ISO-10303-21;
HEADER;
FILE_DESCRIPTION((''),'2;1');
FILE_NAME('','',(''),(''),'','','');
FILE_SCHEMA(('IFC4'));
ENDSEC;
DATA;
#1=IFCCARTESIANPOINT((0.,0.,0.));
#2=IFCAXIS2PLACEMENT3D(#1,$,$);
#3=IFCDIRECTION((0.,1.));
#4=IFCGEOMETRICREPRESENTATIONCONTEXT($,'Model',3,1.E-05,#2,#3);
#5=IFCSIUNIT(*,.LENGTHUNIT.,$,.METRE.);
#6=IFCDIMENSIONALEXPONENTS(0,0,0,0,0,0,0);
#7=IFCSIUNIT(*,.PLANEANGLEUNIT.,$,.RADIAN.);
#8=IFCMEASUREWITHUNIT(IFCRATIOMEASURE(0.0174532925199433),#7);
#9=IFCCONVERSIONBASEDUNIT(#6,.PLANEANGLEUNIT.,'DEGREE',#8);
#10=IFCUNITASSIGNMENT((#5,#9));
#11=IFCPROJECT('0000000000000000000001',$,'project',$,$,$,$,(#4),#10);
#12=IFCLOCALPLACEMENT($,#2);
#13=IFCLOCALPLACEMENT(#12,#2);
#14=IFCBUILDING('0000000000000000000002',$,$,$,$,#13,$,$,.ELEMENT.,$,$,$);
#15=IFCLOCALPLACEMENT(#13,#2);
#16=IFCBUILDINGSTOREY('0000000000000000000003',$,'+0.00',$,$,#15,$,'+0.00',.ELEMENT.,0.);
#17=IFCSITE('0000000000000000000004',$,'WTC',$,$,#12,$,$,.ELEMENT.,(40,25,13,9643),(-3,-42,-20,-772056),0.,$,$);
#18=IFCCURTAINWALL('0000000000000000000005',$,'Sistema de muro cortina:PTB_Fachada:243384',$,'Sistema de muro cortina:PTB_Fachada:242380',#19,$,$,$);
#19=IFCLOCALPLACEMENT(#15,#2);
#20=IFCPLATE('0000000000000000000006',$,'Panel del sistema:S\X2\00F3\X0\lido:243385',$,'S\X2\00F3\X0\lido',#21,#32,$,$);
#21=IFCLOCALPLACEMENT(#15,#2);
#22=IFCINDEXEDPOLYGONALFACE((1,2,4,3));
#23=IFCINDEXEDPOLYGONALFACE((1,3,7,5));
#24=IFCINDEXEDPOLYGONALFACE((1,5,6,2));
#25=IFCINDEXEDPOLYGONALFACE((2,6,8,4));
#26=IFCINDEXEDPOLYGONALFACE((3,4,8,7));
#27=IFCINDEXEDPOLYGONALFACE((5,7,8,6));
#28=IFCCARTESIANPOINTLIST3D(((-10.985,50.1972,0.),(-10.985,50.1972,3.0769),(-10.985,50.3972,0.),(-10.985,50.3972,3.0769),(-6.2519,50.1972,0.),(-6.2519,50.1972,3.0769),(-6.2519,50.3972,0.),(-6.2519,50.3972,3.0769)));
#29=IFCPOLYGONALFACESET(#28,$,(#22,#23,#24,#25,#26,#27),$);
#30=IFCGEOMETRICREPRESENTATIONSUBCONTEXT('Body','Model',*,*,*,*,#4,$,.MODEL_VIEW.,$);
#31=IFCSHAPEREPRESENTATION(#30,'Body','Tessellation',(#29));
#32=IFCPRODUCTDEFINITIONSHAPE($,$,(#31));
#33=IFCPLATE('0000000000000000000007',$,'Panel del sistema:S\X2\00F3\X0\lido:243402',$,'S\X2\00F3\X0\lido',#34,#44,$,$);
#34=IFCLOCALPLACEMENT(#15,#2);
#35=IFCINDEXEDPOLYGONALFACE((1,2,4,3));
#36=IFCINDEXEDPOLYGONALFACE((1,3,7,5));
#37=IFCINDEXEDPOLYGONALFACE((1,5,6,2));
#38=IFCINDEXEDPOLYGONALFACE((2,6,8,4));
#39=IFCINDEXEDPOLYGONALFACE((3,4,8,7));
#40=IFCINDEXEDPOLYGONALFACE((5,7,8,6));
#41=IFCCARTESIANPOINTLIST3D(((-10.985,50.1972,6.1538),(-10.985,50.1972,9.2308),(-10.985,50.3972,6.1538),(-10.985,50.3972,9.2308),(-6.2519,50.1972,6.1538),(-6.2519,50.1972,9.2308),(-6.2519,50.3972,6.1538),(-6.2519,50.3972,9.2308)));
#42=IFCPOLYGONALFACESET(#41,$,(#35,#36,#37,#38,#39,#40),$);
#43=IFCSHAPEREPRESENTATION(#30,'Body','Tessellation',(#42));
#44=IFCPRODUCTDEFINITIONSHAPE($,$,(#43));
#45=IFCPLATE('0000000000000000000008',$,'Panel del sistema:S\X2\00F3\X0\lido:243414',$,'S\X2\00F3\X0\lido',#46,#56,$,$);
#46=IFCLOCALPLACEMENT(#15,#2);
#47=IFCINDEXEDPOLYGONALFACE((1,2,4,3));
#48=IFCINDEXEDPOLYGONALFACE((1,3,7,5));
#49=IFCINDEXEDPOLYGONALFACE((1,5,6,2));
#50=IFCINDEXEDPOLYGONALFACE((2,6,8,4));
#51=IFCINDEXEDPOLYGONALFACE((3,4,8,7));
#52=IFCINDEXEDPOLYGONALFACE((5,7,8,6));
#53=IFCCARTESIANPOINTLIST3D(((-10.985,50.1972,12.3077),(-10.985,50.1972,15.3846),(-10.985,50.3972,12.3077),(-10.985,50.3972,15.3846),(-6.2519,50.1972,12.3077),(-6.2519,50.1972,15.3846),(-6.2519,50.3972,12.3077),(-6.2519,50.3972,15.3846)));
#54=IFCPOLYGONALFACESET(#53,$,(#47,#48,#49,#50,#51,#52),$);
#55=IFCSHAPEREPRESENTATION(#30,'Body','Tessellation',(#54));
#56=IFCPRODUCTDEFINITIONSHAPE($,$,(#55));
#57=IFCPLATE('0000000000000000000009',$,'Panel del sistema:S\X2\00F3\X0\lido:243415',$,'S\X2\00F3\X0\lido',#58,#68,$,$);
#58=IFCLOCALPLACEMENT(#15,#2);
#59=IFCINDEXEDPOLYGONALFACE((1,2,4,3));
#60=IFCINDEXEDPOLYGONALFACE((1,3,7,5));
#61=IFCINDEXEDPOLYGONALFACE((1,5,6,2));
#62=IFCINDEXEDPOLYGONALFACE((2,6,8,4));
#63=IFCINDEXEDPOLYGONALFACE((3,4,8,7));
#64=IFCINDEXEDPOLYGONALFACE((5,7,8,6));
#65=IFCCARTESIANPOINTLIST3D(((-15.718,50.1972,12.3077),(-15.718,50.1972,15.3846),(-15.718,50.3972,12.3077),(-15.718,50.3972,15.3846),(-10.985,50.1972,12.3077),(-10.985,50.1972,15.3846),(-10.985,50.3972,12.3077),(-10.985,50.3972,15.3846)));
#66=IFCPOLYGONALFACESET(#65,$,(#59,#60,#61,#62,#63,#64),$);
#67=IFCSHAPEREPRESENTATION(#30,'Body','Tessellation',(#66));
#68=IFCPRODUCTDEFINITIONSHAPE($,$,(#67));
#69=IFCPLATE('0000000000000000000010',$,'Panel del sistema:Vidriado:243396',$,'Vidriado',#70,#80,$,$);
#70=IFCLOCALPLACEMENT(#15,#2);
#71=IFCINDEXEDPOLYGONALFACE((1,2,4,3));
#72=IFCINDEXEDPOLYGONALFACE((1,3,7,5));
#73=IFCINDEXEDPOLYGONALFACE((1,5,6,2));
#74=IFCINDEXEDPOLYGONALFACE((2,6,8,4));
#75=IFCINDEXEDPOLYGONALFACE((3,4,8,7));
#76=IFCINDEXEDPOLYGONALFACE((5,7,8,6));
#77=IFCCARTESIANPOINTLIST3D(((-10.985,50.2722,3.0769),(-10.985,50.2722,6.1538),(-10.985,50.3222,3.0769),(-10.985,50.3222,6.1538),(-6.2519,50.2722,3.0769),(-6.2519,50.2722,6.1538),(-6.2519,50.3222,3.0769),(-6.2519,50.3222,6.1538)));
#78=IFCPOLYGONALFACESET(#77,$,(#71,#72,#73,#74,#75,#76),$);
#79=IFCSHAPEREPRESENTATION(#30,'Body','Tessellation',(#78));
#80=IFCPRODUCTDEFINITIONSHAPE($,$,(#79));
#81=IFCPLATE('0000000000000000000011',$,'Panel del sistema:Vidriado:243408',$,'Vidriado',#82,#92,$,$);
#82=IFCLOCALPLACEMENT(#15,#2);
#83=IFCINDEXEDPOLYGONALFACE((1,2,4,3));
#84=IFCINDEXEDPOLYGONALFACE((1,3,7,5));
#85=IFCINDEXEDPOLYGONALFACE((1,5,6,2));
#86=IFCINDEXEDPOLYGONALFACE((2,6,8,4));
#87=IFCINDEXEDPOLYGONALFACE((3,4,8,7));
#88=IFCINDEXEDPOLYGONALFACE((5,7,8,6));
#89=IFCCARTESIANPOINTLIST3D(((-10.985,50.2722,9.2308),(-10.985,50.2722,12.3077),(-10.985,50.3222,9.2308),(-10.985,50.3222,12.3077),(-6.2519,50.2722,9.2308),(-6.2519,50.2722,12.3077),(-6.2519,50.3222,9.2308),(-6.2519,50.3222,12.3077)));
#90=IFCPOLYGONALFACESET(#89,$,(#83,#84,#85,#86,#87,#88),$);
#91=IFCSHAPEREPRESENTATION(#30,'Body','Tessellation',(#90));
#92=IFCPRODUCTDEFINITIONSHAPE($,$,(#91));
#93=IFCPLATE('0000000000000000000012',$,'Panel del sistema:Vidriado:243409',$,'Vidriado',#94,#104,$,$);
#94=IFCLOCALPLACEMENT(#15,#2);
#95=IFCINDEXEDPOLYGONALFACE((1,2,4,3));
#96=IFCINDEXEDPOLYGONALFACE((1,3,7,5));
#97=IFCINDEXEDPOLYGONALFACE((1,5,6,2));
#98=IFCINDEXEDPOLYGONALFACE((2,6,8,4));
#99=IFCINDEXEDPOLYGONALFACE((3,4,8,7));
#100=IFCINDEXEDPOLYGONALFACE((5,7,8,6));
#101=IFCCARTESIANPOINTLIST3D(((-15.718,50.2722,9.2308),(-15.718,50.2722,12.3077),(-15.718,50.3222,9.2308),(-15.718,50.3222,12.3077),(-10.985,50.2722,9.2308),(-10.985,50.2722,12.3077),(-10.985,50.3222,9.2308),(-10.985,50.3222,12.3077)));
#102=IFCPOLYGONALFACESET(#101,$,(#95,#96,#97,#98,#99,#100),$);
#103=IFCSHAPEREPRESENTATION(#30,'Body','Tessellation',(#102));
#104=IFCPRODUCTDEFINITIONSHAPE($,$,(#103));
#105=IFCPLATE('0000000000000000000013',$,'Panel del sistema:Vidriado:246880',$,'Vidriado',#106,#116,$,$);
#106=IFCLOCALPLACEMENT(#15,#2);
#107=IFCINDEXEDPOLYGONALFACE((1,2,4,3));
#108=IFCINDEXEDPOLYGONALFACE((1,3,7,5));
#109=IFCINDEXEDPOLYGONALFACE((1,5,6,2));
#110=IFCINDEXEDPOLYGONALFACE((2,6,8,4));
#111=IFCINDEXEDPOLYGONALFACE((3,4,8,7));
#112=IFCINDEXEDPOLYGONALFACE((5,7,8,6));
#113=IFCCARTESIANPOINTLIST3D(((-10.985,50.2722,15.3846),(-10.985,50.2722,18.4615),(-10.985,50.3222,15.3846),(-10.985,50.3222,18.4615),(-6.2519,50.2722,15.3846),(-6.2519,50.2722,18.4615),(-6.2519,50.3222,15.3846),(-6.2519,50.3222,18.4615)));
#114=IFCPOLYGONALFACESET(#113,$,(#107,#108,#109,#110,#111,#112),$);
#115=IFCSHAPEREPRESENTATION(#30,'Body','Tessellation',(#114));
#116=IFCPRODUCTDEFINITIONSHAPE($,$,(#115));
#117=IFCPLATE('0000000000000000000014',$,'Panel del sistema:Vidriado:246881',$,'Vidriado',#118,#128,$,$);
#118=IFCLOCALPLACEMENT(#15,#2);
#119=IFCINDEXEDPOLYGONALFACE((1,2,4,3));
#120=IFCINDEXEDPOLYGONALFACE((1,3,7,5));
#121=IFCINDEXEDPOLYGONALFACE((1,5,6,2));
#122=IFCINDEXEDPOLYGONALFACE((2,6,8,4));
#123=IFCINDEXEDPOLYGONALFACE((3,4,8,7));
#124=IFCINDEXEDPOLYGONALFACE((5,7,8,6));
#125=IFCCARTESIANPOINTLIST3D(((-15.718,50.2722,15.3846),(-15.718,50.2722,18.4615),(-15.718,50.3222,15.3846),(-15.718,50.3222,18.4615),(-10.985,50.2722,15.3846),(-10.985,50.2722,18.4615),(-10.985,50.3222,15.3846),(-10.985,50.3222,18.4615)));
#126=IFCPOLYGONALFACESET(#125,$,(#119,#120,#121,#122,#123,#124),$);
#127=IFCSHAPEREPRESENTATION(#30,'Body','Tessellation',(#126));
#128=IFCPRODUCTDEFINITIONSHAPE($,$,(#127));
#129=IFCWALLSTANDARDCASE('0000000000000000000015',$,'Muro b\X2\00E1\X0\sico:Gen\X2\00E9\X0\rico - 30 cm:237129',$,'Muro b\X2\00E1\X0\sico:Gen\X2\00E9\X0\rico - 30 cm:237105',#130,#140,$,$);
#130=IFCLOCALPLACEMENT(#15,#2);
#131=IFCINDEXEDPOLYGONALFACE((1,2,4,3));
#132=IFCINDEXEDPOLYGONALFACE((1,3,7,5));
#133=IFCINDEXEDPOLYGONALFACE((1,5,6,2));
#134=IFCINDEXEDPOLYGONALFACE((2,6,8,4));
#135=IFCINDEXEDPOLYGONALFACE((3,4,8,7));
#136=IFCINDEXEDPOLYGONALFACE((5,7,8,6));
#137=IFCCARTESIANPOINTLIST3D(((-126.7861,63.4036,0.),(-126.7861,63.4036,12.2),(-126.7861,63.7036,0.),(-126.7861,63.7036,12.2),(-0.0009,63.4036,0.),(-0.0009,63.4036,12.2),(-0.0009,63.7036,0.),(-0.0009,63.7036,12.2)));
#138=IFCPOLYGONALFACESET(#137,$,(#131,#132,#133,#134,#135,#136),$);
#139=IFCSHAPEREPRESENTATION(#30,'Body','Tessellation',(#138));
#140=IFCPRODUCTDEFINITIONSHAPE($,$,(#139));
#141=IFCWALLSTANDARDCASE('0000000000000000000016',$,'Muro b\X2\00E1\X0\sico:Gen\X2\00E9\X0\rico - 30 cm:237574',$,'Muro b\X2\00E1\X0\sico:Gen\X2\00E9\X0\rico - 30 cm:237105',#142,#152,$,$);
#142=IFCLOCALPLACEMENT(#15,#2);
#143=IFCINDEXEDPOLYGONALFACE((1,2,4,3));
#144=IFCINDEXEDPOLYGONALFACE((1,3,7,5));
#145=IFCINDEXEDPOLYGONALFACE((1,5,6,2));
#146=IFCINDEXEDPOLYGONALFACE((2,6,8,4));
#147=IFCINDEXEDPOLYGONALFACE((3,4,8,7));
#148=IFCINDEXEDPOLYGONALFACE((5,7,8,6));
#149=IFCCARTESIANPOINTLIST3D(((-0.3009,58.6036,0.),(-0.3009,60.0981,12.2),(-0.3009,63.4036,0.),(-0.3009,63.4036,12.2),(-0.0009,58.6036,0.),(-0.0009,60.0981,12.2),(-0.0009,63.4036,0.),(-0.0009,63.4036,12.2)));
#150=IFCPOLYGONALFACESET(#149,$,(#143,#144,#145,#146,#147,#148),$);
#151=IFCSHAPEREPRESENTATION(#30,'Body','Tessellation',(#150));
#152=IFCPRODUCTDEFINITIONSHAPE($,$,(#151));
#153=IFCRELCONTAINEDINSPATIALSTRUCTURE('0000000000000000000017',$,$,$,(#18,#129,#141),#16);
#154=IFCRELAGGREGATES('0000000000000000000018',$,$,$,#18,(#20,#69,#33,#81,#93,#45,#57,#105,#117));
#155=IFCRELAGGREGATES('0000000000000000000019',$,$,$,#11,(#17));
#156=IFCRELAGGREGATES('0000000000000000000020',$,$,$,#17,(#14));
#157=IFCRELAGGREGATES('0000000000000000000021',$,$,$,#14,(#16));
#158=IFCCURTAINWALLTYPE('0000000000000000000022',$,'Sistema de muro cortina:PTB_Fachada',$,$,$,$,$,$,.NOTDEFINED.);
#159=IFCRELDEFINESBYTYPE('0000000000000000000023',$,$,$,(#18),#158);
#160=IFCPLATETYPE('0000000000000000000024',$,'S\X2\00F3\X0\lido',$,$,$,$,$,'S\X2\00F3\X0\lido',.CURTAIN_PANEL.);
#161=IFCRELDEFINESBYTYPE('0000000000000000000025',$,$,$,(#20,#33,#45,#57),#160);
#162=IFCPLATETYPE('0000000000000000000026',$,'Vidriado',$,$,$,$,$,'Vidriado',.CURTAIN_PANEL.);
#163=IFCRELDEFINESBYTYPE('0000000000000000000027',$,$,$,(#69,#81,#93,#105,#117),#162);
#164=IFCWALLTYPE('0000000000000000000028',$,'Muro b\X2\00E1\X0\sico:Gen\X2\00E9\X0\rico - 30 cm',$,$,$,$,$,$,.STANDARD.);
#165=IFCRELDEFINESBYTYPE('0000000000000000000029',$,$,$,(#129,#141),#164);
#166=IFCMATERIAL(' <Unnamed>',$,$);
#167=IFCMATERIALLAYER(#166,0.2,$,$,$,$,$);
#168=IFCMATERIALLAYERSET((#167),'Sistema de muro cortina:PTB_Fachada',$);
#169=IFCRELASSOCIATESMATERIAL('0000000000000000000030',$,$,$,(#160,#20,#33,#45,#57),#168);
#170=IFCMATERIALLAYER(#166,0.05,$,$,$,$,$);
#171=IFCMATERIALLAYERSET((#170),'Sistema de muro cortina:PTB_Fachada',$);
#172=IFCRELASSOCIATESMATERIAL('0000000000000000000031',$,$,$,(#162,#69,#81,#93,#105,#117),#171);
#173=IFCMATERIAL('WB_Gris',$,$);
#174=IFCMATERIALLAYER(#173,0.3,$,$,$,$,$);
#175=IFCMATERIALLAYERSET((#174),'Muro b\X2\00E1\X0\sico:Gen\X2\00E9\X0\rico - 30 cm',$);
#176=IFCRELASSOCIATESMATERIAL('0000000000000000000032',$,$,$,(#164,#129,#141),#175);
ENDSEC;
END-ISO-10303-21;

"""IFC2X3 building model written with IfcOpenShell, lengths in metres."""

from ifc_helpers import new_model, entity, si_unit, converted_unit, direction, frame, frame_2d, origin, origin_2d_with_axis, place, context, subcontext, project, spatial, polyline, rectangle, extrude, clip, halfspace, bounded_halfspace, source, transform, mapped, material, layer, layer_set, layer_usage, type_object, type_shapes, element, aggregate, save


model = new_model("IFC2X3")

# Units and contexts
model_context = context("Model", 3, precision=1e-05, world=origin(), true_north=direction((0.0, 1.0)))
body_context = subcontext(model_context, "Body", "Model", "MODEL_VIEW")
ifc_project = project(units=[si_unit("LENGTHUNIT", "METRE"), converted_unit("PLANEANGLEUNIT", "DEGREE", entity("IfcRatioMeasure", 0.0174532925199433), si_unit("PLANEANGLEUNIT", "RADIAN"), dimensions=[0, 0, 0, 0, 0, 0, 0])], contexts=[model_context])

# Site, building, storey
site_placement = place(None, origin())
site = spatial("IfcSite", under=ifc_project, at=site_placement, Name="WTC", CompositionType="ELEMENT", RefLatitude=(40, 25, 13, 9643), RefLongitude=(-3, -42, -20, -772056), RefElevation=0.0)
building_placement = place(site_placement, origin())
building = spatial("IfcBuilding", under=site, at=building_placement, CompositionType="ELEMENT")
storey_placement = place(building_placement, origin())
storey = spatial("IfcBuildingStorey", under=building, at=storey_placement, Name="+0.00", LongName="+0.00", CompositionType="ELEMENT", Elevation=0.0)

# Curtain wall, plates
curtain_wall_type = type_object("IfcCurtainWallType", Name="Sistema de muro cortina:PTB_Fachada", PredefinedType="NOTDEFINED")
ifc_material_1 = material(Name=" <Unnamed>")
ifc_layer_1 = layer(ifc_material_1, 0.2)
ifc_layer_set_1 = layer_set([ifc_layer_1], Name="Sistema de muro cortina:PTB_Fachada")
ifc_layer_2 = layer(ifc_material_1, 0.05)
ifc_layer_set_2 = layer_set([ifc_layer_2], Name="Sistema de muro cortina:PTB_Fachada")
curtain_wall_1_placement = place(storey_placement, origin())
curtain_wall_1 = element("IfcCurtainWall", 1, at=curtain_wall_1_placement, inside=storey, type_object=curtain_wall_type, Name="Sistema de muro cortina:PTB_Fachada:243384", ObjectType="Sistema de muro cortina:PTB_Fachada:242380")
ifc_layer_usage_1 = layer_usage(ifc_layer_set_1, "AXIS3", "POSITIVE", 0.0)
plate_type_1 = type_object("IfcPlateType", Name="Sólido", ElementType="Sólido", PredefinedType="CURTAIN_PANEL", material=ifc_layer_set_1)
shared_shape_1 = source(origin(), body_context, "Body", "SweptSolid", [
    extrude(rectangle(XDim=0.2, YDim=4.7331, at=frame_2d((0.0, 0.0), x_axis=(1.0, 0.0))), frame((0.0, 0.0, 0.0), z_axis=(0.0, 0.0, 1.0), x_axis=(0.0, 1.0, 0.0)), (0.0, 0.0, 1.0), 3.0769),
])
type_shapes(plate_type_1, [shared_shape_1])
plate_1_placement = place(curtain_wall_1_placement, frame((-8.6184, 50.2972, 0.0), z_axis=(0.0, 0.0, 1.0), x_axis=(-1.0, 0.0, 0.0)))
plate_1 = element("IfcPlate", 2, at=plate_1_placement, type_object=plate_type_1, material=ifc_layer_usage_1, Name="Panel del sistema:Sólido:243385", ObjectType="Sólido", context=body_context, shape_type="MappedRepresentation", body=[
    mapped(shared_shape_1, transform((0.0, 0.0, 0.0), scale=1.0)),
])
ifc_layer_usage_2 = layer_usage(ifc_layer_set_1, "AXIS3", "POSITIVE", 0.0)
plate_2_placement = place(curtain_wall_1_placement, frame((-8.6184, 50.2972, 6.1538), z_axis=(0.0, 0.0, 1.0), x_axis=(-1.0, 0.0, 0.0)))
plate_2 = element("IfcPlate", 3, at=plate_2_placement, type_object=plate_type_1, material=ifc_layer_usage_2, Name="Panel del sistema:Sólido:243402", ObjectType="Sólido", context=body_context, shape_type="MappedRepresentation", body=[
    mapped(shared_shape_1, transform((0.0, 0.0, 0.0), scale=1.0)),
])
ifc_layer_usage_3 = layer_usage(ifc_layer_set_1, "AXIS3", "POSITIVE", 0.0)
plate_3_placement = place(curtain_wall_1_placement, frame((-8.6184, 50.2972, 12.3077), z_axis=(0.0, 0.0, 1.0), x_axis=(-1.0, 0.0, 0.0)))
plate_3 = element("IfcPlate", 4, at=plate_3_placement, type_object=plate_type_1, material=ifc_layer_usage_3, Name="Panel del sistema:Sólido:243414", ObjectType="Sólido", context=body_context, shape_type="MappedRepresentation", body=[
    mapped(shared_shape_1, transform((0.0, 0.0, 0.0), scale=1.0)),
])
ifc_layer_usage_4 = layer_usage(ifc_layer_set_1, "AXIS3", "POSITIVE", 0.0)
plate_4_placement = place(curtain_wall_1_placement, frame((-13.3515, 50.2972, 12.3077), z_axis=(0.0, 0.0, 1.0), x_axis=(-1.0, 0.0, 0.0)))
plate_4 = element("IfcPlate", 5, at=plate_4_placement, type_object=plate_type_1, material=ifc_layer_usage_4, Name="Panel del sistema:Sólido:243415", ObjectType="Sólido", context=body_context, shape_type="MappedRepresentation", body=[
    mapped(shared_shape_1, transform((0.0, 0.0, 0.0), scale=1.0)),
])
ifc_layer_usage_5 = layer_usage(ifc_layer_set_2, "AXIS3", "POSITIVE", 0.0)
plate_type_2 = type_object("IfcPlateType", Name="Vidriado", ElementType="Vidriado", PredefinedType="CURTAIN_PANEL", material=ifc_layer_set_2)
shared_shape_2 = source(origin(), body_context, "Body", "SweptSolid", [
    extrude(rectangle(XDim=0.05, YDim=4.7331, at=origin_2d_with_axis()), frame((0.0, 0.0, 0.0), z_axis=(0.0, 0.0, 1.0), x_axis=(0.0, 1.0, 0.0)), (0.0, 0.0, 1.0), 3.0769),
])
type_shapes(plate_type_2, [shared_shape_2])
plate_5_placement = place(curtain_wall_1_placement, frame((-8.6184, 50.2972, 3.0769), z_axis=(0.0, 0.0, 1.0), x_axis=(-1.0, 0.0, 0.0)))
plate_5 = element("IfcPlate", 6, at=plate_5_placement, type_object=plate_type_2, material=ifc_layer_usage_5, Name="Panel del sistema:Vidriado:243396", ObjectType="Vidriado", context=body_context, shape_type="MappedRepresentation", body=[
    mapped(shared_shape_2, transform((0.0, 0.0, 0.0), scale=1.0)),
])
ifc_layer_usage_6 = layer_usage(ifc_layer_set_2, "AXIS3", "POSITIVE", 0.0)
plate_6_placement = place(curtain_wall_1_placement, frame((-8.6184, 50.2972, 9.2308), z_axis=(0.0, 0.0, 1.0), x_axis=(-1.0, 0.0, 0.0)))
plate_6 = element("IfcPlate", 7, at=plate_6_placement, type_object=plate_type_2, material=ifc_layer_usage_6, Name="Panel del sistema:Vidriado:243408", ObjectType="Vidriado", context=body_context, shape_type="MappedRepresentation", body=[
    mapped(shared_shape_2, transform((0.0, 0.0, 0.0), scale=1.0)),
])
ifc_layer_usage_7 = layer_usage(ifc_layer_set_2, "AXIS3", "POSITIVE", 0.0)
plate_7_placement = place(curtain_wall_1_placement, frame((-13.3515, 50.2972, 9.2308), z_axis=(0.0, 0.0, 1.0), x_axis=(-1.0, 0.0, 0.0)))
plate_7 = element("IfcPlate", 8, at=plate_7_placement, type_object=plate_type_2, material=ifc_layer_usage_7, Name="Panel del sistema:Vidriado:243409", ObjectType="Vidriado", context=body_context, shape_type="MappedRepresentation", body=[
    mapped(shared_shape_2, transform((0.0, 0.0, 0.0), scale=1.0)),
])
ifc_layer_usage_8 = layer_usage(ifc_layer_set_2, "AXIS3", "POSITIVE", 0.0)
plate_8_placement = place(curtain_wall_1_placement, frame((-8.6184, 50.2972, 15.3846), z_axis=(0.0, 0.0, 1.0), x_axis=(-1.0, 0.0, 0.0)))
plate_8 = element("IfcPlate", 9, at=plate_8_placement, type_object=plate_type_2, material=ifc_layer_usage_8, Name="Panel del sistema:Vidriado:246880", ObjectType="Vidriado", context=body_context, shape_type="MappedRepresentation", body=[
    mapped(shared_shape_2, transform((0.0, 0.0, 0.0), scale=1.0)),
])
ifc_layer_usage_9 = layer_usage(ifc_layer_set_2, "AXIS3", "POSITIVE", 0.0)
plate_9_placement = place(curtain_wall_1_placement, frame((-13.3515, 50.2972, 15.3846), z_axis=(0.0, 0.0, 1.0), x_axis=(-1.0, 0.0, 0.0)))
plate_9 = element("IfcPlate", 10, at=plate_9_placement, type_object=plate_type_2, material=ifc_layer_usage_9, Name="Panel del sistema:Vidriado:246881", ObjectType="Vidriado", context=body_context, shape_type="MappedRepresentation", body=[
    mapped(shared_shape_2, transform((0.0, 0.0, 0.0), scale=1.0)),
])
aggregate(curtain_wall_1, [plate_1, plate_5, plate_2, plate_6, plate_7, plate_3, plate_4, plate_8, plate_9])

# Walls
ifc_material_2 = material(Name="WB_Gris")
ifc_layer_3 = layer(ifc_material_2, 0.3)
ifc_layer_set_3 = layer_set([ifc_layer_3], Name="Muro básico:Genérico - 30 cm")
ifc_layer_usage_10 = layer_usage(ifc_layer_set_3, "AXIS2", "POSITIVE", -0.15)
wall_type = type_object("IfcWallType", Name="Muro básico:Genérico - 30 cm", PredefinedType="STANDARD", material=ifc_layer_set_3)
wall_1_placement = place(storey_placement, frame((-0.0009, 63.5536, 0.0), z_axis=(0.0, 0.0, 1.0), x_axis=(-1.0, 0.0, 0.0)))
element("IfcWallStandardCase", 11, at=wall_1_placement, inside=storey, type_object=wall_type, material=ifc_layer_usage_10, Name="Muro básico:Genérico - 30 cm:237129", ObjectType="Muro básico:Genérico - 30 cm:237105", context=body_context, shape_type="Clipping", body=[
    clip(extrude(rectangle(XDim=126.7852, YDim=0.3, at=frame_2d((63.3926, 0.0), x_axis=(-1.0, 0.0))), origin(), (0.0, 0.0, 1.0), 12.2), bounded_halfspace(frame((0.0, -0.15, 12.2), z_axis=(0.0, 0.0, 1.0), x_axis=(0.0, 1.0, 0.0)), False, frame((0.0, -0.15, 12.2), z_axis=(0.0, 0.0, 1.0), x_axis=(0.0, 1.0, 0.0)), polyline([(0.0, 0.0), (0.0, -126.7852), (0.3, -126.7852), (0.3, -126.4852), (0.3, 0.0), (0.0, 0.0)]))),
])
ifc_layer_usage_11 = layer_usage(ifc_layer_set_3, "AXIS2", "NEGATIVE", 0.15)
wall_2_placement = place(storey_placement, frame((-0.1509, 63.4036, 0.0), z_axis=(0.0, 0.0, 1.0), x_axis=(0.0, -1.0, 0.0)))
element("IfcWallStandardCase", 12, at=wall_2_placement, inside=storey, type_object=wall_type, material=ifc_layer_usage_11, Name="Muro básico:Genérico - 30 cm:237574", ObjectType="Muro básico:Genérico - 30 cm:237105", context=body_context, shape_type="Clipping", body=[
    clip(clip(extrude(rectangle(XDim=4.8, YDim=0.3, at=frame_2d((2.4, 0.0), x_axis=(-1.0, 0.0))), origin(), (0.0, 0.0, 1.0), 12.2), bounded_halfspace(frame((0.0, -0.15, 12.2)), False, frame((0.0, -0.15, 12.2)), polyline([(0.0, 0.0), (3.3055, 0.0), (3.3055, 0.3), (0.0, 0.3), (0.0, 0.0)]))), halfspace(frame((4.8, -0.15, 0.0), z_axis=(0.99258, 0.0, 0.121593), x_axis=(0.0, 1.0, 0.0)), False)),
])

save(model, "model.ifc")
